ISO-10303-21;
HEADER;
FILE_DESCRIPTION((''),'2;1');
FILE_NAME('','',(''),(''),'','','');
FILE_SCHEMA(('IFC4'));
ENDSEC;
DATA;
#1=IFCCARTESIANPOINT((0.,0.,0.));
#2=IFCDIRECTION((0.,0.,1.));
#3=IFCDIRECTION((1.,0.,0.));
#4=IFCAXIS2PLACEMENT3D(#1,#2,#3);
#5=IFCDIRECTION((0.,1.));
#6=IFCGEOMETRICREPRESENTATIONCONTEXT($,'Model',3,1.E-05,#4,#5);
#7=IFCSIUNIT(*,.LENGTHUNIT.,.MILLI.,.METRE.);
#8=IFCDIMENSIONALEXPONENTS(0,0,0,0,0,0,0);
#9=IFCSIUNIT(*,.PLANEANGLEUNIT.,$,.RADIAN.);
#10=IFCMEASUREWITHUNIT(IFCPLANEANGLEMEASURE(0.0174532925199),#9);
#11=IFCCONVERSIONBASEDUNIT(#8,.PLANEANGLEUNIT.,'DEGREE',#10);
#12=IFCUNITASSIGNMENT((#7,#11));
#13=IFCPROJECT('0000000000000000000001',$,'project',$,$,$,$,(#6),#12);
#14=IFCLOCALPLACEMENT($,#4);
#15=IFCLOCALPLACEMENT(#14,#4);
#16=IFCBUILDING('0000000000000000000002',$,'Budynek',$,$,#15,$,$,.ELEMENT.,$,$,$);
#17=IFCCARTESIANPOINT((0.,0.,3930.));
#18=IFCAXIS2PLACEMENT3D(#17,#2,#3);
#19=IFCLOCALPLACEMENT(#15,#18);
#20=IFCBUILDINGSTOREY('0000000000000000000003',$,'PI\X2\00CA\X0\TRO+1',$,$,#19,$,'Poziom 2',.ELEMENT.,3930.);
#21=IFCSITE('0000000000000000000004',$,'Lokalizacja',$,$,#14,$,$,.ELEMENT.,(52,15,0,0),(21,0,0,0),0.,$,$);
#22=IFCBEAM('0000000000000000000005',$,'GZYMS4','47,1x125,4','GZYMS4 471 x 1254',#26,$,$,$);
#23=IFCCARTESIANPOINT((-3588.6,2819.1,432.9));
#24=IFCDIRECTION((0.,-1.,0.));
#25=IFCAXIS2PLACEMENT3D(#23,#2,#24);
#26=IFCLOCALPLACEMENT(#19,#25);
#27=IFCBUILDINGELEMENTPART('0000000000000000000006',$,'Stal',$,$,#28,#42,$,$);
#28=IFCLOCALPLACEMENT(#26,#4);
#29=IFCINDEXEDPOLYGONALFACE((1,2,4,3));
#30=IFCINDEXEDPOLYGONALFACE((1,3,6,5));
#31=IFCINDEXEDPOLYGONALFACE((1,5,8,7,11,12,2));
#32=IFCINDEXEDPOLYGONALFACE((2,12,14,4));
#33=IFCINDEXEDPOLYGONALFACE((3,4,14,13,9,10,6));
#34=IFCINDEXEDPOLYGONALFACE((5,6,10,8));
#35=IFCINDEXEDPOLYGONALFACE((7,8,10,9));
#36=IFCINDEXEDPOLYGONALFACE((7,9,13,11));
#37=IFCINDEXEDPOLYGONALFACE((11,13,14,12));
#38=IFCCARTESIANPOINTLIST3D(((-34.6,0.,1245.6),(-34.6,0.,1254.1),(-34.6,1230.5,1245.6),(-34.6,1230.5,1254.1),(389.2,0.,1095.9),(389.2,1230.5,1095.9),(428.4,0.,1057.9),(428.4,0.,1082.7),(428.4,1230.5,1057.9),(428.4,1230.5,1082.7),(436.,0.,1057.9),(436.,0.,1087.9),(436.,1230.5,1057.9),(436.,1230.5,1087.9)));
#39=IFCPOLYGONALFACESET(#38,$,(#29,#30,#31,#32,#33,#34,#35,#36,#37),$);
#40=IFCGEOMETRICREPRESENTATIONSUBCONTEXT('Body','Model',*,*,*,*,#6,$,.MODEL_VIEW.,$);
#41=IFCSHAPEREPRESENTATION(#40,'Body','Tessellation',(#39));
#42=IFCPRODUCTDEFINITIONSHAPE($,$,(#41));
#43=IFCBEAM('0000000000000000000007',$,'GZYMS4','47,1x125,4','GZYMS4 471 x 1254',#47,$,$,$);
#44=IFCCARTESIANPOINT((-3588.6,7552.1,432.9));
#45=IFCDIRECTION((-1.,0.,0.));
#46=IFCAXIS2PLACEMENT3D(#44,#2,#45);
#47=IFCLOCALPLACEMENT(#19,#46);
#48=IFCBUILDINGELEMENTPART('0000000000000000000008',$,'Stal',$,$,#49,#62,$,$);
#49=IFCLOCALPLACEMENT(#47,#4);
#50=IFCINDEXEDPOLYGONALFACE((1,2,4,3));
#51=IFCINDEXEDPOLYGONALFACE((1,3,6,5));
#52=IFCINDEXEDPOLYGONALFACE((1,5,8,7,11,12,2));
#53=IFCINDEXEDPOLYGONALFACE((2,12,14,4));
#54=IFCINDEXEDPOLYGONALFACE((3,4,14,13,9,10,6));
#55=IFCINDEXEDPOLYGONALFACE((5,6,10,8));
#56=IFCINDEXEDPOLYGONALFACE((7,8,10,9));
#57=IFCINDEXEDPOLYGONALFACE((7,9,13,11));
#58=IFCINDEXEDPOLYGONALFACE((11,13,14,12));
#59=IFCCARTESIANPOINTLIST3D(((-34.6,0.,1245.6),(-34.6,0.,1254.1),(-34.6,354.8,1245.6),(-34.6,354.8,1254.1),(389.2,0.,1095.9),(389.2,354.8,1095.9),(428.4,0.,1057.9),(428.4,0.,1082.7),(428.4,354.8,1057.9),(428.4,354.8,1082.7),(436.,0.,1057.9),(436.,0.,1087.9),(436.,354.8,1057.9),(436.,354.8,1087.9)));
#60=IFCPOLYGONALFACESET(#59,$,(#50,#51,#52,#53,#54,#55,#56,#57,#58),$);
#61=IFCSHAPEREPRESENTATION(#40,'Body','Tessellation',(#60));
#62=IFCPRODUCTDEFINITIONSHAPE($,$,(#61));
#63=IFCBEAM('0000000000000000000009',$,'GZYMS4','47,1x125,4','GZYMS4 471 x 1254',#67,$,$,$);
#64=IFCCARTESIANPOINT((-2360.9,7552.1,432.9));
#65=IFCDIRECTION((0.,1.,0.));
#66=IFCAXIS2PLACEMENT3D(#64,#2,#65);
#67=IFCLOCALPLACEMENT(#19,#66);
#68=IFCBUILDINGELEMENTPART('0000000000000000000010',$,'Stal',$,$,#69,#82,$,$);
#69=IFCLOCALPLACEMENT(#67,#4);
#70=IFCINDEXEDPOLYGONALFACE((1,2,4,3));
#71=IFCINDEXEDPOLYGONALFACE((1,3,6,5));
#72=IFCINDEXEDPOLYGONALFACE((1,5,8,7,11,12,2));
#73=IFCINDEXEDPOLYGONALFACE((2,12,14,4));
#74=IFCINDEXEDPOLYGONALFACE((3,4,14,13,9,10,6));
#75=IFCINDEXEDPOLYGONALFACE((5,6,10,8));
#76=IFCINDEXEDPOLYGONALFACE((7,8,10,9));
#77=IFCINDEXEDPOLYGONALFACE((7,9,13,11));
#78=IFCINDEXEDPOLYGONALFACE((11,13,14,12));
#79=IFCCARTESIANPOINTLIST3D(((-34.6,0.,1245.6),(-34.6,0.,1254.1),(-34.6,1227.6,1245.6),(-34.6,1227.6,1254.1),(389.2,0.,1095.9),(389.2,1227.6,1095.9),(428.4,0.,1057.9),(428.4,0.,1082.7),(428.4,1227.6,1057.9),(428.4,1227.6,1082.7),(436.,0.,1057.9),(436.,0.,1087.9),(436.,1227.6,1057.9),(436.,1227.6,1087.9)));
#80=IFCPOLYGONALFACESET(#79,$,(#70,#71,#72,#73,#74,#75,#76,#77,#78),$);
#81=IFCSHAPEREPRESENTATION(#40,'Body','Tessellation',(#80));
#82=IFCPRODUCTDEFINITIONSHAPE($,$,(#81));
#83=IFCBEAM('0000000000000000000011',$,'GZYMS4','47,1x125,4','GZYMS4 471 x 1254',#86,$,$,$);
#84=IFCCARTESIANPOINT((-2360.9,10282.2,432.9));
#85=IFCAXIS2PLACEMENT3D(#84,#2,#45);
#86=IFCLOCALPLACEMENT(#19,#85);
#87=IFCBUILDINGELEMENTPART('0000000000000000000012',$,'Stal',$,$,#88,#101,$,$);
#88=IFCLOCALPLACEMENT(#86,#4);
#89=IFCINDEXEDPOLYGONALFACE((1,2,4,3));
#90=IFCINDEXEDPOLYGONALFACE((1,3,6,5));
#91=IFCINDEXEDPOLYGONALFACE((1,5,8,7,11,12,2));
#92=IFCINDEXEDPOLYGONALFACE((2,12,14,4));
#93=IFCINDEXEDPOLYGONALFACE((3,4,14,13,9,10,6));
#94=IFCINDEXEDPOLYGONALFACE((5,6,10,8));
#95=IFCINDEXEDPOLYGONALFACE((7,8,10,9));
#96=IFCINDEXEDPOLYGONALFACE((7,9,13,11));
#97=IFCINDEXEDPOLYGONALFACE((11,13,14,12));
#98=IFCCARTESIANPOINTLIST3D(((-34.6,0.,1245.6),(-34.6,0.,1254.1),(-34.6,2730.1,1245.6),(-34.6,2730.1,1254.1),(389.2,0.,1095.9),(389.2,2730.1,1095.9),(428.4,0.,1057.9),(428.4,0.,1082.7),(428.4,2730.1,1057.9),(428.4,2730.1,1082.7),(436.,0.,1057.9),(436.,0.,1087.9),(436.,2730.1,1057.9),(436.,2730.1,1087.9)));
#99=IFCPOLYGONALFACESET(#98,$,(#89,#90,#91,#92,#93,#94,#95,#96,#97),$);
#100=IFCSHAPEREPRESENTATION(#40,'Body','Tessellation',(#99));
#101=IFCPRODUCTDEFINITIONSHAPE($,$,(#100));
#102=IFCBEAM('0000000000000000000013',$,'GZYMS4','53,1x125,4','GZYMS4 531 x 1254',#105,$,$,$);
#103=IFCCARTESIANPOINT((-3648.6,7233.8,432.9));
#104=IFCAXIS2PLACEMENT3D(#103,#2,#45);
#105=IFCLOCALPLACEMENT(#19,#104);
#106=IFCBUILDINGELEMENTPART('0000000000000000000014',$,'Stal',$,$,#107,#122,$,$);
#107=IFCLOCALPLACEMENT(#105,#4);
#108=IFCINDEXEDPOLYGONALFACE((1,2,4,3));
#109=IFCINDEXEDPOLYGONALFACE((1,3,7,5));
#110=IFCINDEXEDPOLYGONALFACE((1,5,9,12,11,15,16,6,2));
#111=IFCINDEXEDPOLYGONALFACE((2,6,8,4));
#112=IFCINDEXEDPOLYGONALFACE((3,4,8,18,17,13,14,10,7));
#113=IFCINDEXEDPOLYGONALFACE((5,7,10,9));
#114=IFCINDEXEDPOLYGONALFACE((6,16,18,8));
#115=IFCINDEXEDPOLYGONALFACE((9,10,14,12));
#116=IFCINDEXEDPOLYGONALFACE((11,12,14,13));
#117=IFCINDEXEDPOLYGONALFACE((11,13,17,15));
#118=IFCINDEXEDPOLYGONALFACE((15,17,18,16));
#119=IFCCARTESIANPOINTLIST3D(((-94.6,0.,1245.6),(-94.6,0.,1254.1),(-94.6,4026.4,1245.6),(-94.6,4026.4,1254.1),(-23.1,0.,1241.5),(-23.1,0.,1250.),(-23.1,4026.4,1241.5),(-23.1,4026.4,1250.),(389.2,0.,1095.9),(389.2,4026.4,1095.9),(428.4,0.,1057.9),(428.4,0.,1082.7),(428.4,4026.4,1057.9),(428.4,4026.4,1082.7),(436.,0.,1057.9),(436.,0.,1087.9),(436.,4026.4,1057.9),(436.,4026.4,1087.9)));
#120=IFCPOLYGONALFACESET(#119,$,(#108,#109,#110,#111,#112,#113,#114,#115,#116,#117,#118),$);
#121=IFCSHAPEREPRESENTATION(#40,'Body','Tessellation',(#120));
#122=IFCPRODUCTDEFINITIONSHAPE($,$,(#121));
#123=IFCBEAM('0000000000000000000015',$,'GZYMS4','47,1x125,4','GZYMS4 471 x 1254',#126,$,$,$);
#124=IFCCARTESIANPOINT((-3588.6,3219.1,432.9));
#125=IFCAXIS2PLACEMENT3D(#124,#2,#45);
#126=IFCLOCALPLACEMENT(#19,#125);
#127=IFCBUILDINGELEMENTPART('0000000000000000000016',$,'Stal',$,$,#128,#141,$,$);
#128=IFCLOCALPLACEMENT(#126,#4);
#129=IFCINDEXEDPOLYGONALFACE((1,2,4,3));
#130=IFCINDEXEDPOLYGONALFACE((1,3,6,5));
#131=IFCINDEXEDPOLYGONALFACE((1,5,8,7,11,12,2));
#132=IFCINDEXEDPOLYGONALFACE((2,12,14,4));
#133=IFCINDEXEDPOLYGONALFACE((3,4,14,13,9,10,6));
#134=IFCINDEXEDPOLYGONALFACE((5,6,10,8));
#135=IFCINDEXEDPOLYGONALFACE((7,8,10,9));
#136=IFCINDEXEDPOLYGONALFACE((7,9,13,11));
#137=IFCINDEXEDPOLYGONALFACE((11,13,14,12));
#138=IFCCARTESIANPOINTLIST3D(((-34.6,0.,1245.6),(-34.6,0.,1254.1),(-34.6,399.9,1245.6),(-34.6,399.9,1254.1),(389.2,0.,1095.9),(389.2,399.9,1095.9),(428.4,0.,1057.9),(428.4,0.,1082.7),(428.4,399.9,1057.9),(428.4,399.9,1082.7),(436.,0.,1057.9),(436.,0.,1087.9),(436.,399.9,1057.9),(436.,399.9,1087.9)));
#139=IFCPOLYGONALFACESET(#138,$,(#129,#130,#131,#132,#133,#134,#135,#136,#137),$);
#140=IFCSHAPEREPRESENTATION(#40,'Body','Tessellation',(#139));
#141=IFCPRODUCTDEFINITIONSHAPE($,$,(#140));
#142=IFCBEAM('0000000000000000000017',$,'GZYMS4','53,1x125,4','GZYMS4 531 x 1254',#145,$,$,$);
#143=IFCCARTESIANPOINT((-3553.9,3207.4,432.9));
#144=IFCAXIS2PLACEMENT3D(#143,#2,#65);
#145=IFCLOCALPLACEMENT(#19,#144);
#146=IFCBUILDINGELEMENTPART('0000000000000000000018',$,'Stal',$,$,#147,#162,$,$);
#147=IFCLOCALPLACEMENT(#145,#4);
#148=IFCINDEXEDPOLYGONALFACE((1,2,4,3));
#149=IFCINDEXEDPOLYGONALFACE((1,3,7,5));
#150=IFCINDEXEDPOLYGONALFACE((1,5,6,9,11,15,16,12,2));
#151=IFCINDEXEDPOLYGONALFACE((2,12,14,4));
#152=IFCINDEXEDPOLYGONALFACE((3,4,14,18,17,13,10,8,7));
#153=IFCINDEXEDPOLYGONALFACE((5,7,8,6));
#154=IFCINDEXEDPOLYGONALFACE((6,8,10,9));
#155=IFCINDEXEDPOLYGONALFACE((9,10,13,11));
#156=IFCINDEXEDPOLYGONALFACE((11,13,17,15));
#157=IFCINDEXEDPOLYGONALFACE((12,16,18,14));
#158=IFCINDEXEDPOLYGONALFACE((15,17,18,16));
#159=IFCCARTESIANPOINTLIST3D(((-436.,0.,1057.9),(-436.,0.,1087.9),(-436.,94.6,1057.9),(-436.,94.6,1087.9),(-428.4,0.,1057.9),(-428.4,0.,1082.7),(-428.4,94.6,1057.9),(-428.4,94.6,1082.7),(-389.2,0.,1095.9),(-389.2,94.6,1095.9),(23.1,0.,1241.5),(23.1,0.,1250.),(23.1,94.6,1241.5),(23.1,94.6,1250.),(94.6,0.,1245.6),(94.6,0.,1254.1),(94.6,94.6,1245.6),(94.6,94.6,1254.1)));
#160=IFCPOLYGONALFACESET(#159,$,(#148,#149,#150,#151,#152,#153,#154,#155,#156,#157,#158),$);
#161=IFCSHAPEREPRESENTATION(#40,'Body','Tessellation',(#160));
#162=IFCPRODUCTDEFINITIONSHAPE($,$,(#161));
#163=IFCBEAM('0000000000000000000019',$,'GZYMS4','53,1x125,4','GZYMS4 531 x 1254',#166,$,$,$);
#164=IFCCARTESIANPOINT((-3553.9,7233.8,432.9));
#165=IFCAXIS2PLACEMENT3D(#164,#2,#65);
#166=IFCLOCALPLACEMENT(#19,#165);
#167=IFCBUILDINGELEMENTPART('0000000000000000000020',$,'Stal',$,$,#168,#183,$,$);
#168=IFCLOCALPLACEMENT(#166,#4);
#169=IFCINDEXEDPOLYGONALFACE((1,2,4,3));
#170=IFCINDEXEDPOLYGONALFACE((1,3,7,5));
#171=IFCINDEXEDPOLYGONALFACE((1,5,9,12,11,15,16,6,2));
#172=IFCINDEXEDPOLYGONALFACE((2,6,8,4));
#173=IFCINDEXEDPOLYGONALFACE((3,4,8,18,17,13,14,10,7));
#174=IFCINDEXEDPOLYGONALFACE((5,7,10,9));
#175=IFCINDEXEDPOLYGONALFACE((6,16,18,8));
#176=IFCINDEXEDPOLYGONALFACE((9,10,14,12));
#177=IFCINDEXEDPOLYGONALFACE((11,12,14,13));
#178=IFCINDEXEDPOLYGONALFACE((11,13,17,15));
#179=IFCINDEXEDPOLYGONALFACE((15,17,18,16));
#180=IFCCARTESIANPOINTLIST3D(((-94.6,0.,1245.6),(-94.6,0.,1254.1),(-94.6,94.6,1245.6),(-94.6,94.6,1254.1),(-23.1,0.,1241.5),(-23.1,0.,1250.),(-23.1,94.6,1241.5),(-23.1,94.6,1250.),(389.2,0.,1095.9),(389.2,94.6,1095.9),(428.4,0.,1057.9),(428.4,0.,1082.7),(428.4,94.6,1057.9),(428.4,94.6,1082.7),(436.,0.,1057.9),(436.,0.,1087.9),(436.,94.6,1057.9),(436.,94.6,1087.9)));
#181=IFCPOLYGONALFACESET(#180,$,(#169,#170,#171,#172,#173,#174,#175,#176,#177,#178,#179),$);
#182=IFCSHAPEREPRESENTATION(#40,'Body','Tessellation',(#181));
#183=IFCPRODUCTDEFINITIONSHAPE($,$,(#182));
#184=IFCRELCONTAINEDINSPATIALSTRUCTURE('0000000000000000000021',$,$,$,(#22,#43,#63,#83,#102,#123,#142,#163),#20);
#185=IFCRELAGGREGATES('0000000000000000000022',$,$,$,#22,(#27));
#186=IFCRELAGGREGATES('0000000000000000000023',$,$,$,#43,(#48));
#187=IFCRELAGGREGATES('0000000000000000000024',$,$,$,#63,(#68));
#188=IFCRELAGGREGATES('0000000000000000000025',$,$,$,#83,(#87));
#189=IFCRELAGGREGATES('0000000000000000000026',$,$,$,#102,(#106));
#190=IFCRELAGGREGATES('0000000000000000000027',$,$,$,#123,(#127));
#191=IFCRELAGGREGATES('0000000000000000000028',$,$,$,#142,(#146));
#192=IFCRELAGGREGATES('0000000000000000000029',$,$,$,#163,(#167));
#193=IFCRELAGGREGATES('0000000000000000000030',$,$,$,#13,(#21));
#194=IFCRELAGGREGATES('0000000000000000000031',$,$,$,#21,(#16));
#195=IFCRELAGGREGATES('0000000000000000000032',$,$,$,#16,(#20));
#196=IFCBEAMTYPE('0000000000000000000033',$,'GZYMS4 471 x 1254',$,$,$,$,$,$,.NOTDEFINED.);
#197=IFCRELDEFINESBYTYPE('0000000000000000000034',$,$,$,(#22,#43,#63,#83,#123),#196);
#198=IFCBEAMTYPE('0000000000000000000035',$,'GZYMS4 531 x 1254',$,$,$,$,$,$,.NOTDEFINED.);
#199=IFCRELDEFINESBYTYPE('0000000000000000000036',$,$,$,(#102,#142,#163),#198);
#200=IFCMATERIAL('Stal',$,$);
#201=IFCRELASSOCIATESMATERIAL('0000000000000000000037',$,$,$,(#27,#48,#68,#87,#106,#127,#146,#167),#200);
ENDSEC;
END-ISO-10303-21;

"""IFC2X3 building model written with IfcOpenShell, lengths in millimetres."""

from ifc_helpers import new_model, entity, si_unit, converted_unit, direction, frame, origin_with_axes, place, context, subcontext, project, spatial, polyline, outline, extrude, material, type_object, element, aggregate, save


model = new_model("IFC2X3")

# Units and contexts
model_context = context("Model", 3, precision=1e-05, world=origin_with_axes(), true_north=direction((0.0, 1.0)))
body_context = subcontext(model_context, "Body", "Model", "MODEL_VIEW")
ifc_project = project(units=[si_unit("LENGTHUNIT", "METRE", prefix="MILLI"), converted_unit("PLANEANGLEUNIT", "DEGREE", entity("IfcPlaneAngleMeasure", 0.0174532925199), si_unit("PLANEANGLEUNIT", "RADIAN"), dimensions=[0, 0, 0, 0, 0, 0, 0])], contexts=[model_context])

# Site, building, storey
site_placement = place(None, origin_with_axes())
site = spatial("IfcSite", under=ifc_project, at=site_placement, Name="Lokalizacja", CompositionType="ELEMENT", RefLatitude=(52, 15, 0, 0), RefLongitude=(21, 0, 0, 0), RefElevation=0.0)
building_placement = place(site_placement, origin_with_axes())
building = spatial("IfcBuilding", under=site, at=building_placement, Name="Budynek", CompositionType="ELEMENT")
storey_placement = place(building_placement, frame((0.0, 0.0, 3930.0), z_axis=(0.0, 0.0, 1.0), x_axis=(1.0, 0.0, 0.0)))
storey = spatial("IfcBuildingStorey", under=building, at=storey_placement, Name="PIÊTRO+1", LongName="Poziom 2", CompositionType="ELEMENT", Elevation=3930.0)

# Beam, building element part
beam_type_1 = type_object("IfcBeamType", Name="GZYMS4 471 x 1254", PredefinedType="NOTDEFINED")
beam_1_placement = place(storey_placement, frame((-3588.6, 2819.1, 432.9), z_axis=(0.0, 0.0, 1.0), x_axis=(0.0, -1.0, 0.0)))
beam_1 = element("IfcBeam", 1, at=beam_1_placement, inside=storey, type_object=beam_type_1, Name="GZYMS4", Description="47,1x125,4", ObjectType="GZYMS4 471 x 1254")
ifc_material_1 = material(Name="Stal")
building_element_part_1_placement = place(beam_1_placement, origin_with_axes())
building_element_part_1 = element("IfcBuildingElementPart", 2, at=building_element_part_1_placement, material=ifc_material_1, Name="Stal", context=body_context, shape_type="SweptSolid", body=[
    extrude(outline(polyline([(-34.6, 1245.6), (389.2, 1095.9), (428.4, 1082.7), (428.4, 1057.9), (436.0, 1057.9), (436.0, 1087.9), (-34.6, 1254.1), (-34.6, 1245.6)])), frame((0.0, 1230.5, 0.0), z_axis=(0.0, -1.0, 0.0), x_axis=(1.0, 0.0, 0.0)), (0.0, 0.0, 1.0), 1230.5),
])
aggregate(beam_1, [building_element_part_1])

# Beams, building element parts
beam_2_placement = place(storey_placement, frame((-3588.6, 7552.1, 432.9), z_axis=(0.0, 0.0, 1.0), x_axis=(-1.0, 0.0, 0.0)))
beam_2 = element("IfcBeam", 3, at=beam_2_placement, inside=storey, type_object=beam_type_1, Name="GZYMS4", Description="47,1x125,4", ObjectType="GZYMS4 471 x 1254")
building_element_part_2_placement = place(beam_2_placement, origin_with_axes())
building_element_part_2 = element("IfcBuildingElementPart", 4, at=building_element_part_2_placement, material=ifc_material_1, Name="Stal", context=body_context, shape_type="SweptSolid", body=[
    extrude(outline(polyline([(-34.6, 1245.6), (389.2, 1095.9), (428.4, 1082.7), (428.4, 1057.9), (436.0, 1057.9), (436.0, 1087.9), (-34.6, 1254.1), (-34.6, 1245.6)])), frame((0.0, 354.8, 0.0), z_axis=(0.0, -1.0, 0.0), x_axis=(1.0, 0.0, 0.0)), (0.0, 0.0, 1.0), 354.8),
])
aggregate(beam_2, [building_element_part_2])
beam_3_placement = place(storey_placement, frame((-2360.9, 7552.1, 432.9), z_axis=(0.0, 0.0, 1.0), x_axis=(0.0, 1.0, 0.0)))
beam_3 = element("IfcBeam", 5, at=beam_3_placement, inside=storey, type_object=beam_type_1, Name="GZYMS4", Description="47,1x125,4", ObjectType="GZYMS4 471 x 1254")
building_element_part_3_placement = place(beam_3_placement, origin_with_axes())
building_element_part_3 = element("IfcBuildingElementPart", 6, at=building_element_part_3_placement, material=ifc_material_1, Name="Stal", context=body_context, shape_type="SweptSolid", body=[
    extrude(outline(polyline([(-34.6, 1245.6), (389.2, 1095.9), (428.4, 1082.7), (428.4, 1057.9), (436.0, 1057.9), (436.0, 1087.9), (-34.6, 1254.1), (-34.6, 1245.6)])), frame((0.0, 1227.6, 0.0), z_axis=(0.0, -1.0, 0.0), x_axis=(1.0, 0.0, 0.0)), (0.0, 0.0, 1.0), 1227.6),
])
aggregate(beam_3, [building_element_part_3])
beam_4_placement = place(storey_placement, frame((-2360.9, 10282.2, 432.9), z_axis=(0.0, 0.0, 1.0), x_axis=(-1.0, 0.0, 0.0)))
beam_4 = element("IfcBeam", 7, at=beam_4_placement, inside=storey, type_object=beam_type_1, Name="GZYMS4", Description="47,1x125,4", ObjectType="GZYMS4 471 x 1254")
building_element_part_4_placement = place(beam_4_placement, origin_with_axes())
building_element_part_4 = element("IfcBuildingElementPart", 8, at=building_element_part_4_placement, material=ifc_material_1, Name="Stal", context=body_context, shape_type="SweptSolid", body=[
    extrude(outline(polyline([(-34.6, 1245.6), (389.2, 1095.9), (428.4, 1082.7), (428.4, 1057.9), (436.0, 1057.9), (436.0, 1087.9), (-34.6, 1254.1), (-34.6, 1245.6)])), frame((0.0, 2730.1, 0.0), z_axis=(0.0, -1.0, 0.0), x_axis=(1.0, 0.0, 0.0)), (0.0, 0.0, 1.0), 2730.1),
])
aggregate(beam_4, [building_element_part_4])
beam_type_2 = type_object("IfcBeamType", Name="GZYMS4 531 x 1254", PredefinedType="NOTDEFINED")
beam_5_placement = place(storey_placement, frame((-3648.6, 7233.8, 432.9), z_axis=(0.0, 0.0, 1.0), x_axis=(-1.0, 0.0, 0.0)))
beam_5 = element("IfcBeam", 9, at=beam_5_placement, inside=storey, type_object=beam_type_2, Name="GZYMS4", Description="53,1x125,4", ObjectType="GZYMS4 531 x 1254")
building_element_part_5_placement = place(beam_5_placement, origin_with_axes())
building_element_part_5 = element("IfcBuildingElementPart", 10, at=building_element_part_5_placement, material=ifc_material_1, Name="Stal", context=body_context, shape_type="SweptSolid", body=[
    extrude(outline(polyline([(-94.6, 1245.6), (-23.1, 1241.5), (389.2, 1095.9), (428.4, 1082.7), (428.4, 1057.9), (436.0, 1057.9), (436.0, 1087.9), (-23.1, 1250.0), (-94.6, 1254.1), (-94.6, 1245.6)])), frame((0.0, 4026.4, 0.0), z_axis=(0.0, -1.0, 0.0), x_axis=(1.0, 0.0, 0.0)), (0.0, 0.0, 1.0), 4026.4),
])
aggregate(beam_5, [building_element_part_5])
beam_6_placement = place(storey_placement, frame((-3588.6, 3219.1, 432.9), z_axis=(0.0, 0.0, 1.0), x_axis=(-1.0, 0.0, 0.0)))
beam_6 = element("IfcBeam", 11, at=beam_6_placement, inside=storey, type_object=beam_type_1, Name="GZYMS4", Description="47,1x125,4", ObjectType="GZYMS4 471 x 1254")
building_element_part_6_placement = place(beam_6_placement, origin_with_axes())
building_element_part_6 = element("IfcBuildingElementPart", 12, at=building_element_part_6_placement, material=ifc_material_1, Name="Stal", context=body_context, shape_type="SweptSolid", body=[
    extrude(outline(polyline([(-34.6, 1245.6), (389.2, 1095.9), (428.4, 1082.7), (428.4, 1057.9), (436.0, 1057.9), (436.0, 1087.9), (-34.6, 1254.1), (-34.6, 1245.6)])), frame((0.0, 399.9, 0.0), z_axis=(0.0, -1.0, 0.0), x_axis=(1.0, 0.0, 0.0)), (0.0, 0.0, 1.0), 399.9),
])
aggregate(beam_6, [building_element_part_6])
beam_7_placement = place(storey_placement, frame((-3553.9, 3207.4, 432.9), z_axis=(0.0, 0.0, 1.0), x_axis=(0.0, 1.0, 0.0)))
beam_7 = element("IfcBeam", 13, at=beam_7_placement, inside=storey, type_object=beam_type_2, Name="GZYMS4", Description="53,1x125,4", ObjectType="GZYMS4 531 x 1254")
building_element_part_7_placement = place(beam_7_placement, origin_with_axes())
building_element_part_7 = element("IfcBuildingElementPart", 14, at=building_element_part_7_placement, material=ifc_material_1, Name="Stal", context=body_context, shape_type="SweptSolid", body=[
    extrude(outline(polyline([(94.6, 1245.6), (94.6, 1254.1), (23.1, 1250.0), (-436.0, 1087.9), (-436.0, 1057.9), (-428.4, 1057.9), (-428.4, 1082.7), (-389.2, 1095.9), (23.1, 1241.5), (94.6, 1245.6)])), frame((0.0, 94.6, 0.0), z_axis=(0.0, -1.0, 0.0), x_axis=(1.0, 0.0, 0.0)), (0.0, 0.0, 1.0), 94.6),
])
aggregate(beam_7, [building_element_part_7])
beam_8_placement = place(storey_placement, frame((-3553.9, 7233.8, 432.9), z_axis=(0.0, 0.0, 1.0), x_axis=(0.0, 1.0, 0.0)))
beam_8 = element("IfcBeam", 15, at=beam_8_placement, inside=storey, type_object=beam_type_2, Name="GZYMS4", Description="53,1x125,4", ObjectType="GZYMS4 531 x 1254")
building_element_part_8_placement = place(beam_8_placement, origin_with_axes())
building_element_part_8 = element("IfcBuildingElementPart", 16, at=building_element_part_8_placement, material=ifc_material_1, Name="Stal", context=body_context, shape_type="SweptSolid", body=[
    extrude(outline(polyline([(-94.6, 1245.6), (-23.1, 1241.5), (389.2, 1095.9), (428.4, 1082.7), (428.4, 1057.9), (436.0, 1057.9), (436.0, 1087.9), (-23.1, 1250.0), (-94.6, 1254.1), (-94.6, 1245.6)])), frame((0.0, 94.6, 0.0), z_axis=(0.0, -1.0, 0.0), x_axis=(1.0, 0.0, 0.0)), (0.0, 0.0, 1.0), 94.6),
])
aggregate(beam_8, [building_element_part_8])

save(model, "model.ifc")
